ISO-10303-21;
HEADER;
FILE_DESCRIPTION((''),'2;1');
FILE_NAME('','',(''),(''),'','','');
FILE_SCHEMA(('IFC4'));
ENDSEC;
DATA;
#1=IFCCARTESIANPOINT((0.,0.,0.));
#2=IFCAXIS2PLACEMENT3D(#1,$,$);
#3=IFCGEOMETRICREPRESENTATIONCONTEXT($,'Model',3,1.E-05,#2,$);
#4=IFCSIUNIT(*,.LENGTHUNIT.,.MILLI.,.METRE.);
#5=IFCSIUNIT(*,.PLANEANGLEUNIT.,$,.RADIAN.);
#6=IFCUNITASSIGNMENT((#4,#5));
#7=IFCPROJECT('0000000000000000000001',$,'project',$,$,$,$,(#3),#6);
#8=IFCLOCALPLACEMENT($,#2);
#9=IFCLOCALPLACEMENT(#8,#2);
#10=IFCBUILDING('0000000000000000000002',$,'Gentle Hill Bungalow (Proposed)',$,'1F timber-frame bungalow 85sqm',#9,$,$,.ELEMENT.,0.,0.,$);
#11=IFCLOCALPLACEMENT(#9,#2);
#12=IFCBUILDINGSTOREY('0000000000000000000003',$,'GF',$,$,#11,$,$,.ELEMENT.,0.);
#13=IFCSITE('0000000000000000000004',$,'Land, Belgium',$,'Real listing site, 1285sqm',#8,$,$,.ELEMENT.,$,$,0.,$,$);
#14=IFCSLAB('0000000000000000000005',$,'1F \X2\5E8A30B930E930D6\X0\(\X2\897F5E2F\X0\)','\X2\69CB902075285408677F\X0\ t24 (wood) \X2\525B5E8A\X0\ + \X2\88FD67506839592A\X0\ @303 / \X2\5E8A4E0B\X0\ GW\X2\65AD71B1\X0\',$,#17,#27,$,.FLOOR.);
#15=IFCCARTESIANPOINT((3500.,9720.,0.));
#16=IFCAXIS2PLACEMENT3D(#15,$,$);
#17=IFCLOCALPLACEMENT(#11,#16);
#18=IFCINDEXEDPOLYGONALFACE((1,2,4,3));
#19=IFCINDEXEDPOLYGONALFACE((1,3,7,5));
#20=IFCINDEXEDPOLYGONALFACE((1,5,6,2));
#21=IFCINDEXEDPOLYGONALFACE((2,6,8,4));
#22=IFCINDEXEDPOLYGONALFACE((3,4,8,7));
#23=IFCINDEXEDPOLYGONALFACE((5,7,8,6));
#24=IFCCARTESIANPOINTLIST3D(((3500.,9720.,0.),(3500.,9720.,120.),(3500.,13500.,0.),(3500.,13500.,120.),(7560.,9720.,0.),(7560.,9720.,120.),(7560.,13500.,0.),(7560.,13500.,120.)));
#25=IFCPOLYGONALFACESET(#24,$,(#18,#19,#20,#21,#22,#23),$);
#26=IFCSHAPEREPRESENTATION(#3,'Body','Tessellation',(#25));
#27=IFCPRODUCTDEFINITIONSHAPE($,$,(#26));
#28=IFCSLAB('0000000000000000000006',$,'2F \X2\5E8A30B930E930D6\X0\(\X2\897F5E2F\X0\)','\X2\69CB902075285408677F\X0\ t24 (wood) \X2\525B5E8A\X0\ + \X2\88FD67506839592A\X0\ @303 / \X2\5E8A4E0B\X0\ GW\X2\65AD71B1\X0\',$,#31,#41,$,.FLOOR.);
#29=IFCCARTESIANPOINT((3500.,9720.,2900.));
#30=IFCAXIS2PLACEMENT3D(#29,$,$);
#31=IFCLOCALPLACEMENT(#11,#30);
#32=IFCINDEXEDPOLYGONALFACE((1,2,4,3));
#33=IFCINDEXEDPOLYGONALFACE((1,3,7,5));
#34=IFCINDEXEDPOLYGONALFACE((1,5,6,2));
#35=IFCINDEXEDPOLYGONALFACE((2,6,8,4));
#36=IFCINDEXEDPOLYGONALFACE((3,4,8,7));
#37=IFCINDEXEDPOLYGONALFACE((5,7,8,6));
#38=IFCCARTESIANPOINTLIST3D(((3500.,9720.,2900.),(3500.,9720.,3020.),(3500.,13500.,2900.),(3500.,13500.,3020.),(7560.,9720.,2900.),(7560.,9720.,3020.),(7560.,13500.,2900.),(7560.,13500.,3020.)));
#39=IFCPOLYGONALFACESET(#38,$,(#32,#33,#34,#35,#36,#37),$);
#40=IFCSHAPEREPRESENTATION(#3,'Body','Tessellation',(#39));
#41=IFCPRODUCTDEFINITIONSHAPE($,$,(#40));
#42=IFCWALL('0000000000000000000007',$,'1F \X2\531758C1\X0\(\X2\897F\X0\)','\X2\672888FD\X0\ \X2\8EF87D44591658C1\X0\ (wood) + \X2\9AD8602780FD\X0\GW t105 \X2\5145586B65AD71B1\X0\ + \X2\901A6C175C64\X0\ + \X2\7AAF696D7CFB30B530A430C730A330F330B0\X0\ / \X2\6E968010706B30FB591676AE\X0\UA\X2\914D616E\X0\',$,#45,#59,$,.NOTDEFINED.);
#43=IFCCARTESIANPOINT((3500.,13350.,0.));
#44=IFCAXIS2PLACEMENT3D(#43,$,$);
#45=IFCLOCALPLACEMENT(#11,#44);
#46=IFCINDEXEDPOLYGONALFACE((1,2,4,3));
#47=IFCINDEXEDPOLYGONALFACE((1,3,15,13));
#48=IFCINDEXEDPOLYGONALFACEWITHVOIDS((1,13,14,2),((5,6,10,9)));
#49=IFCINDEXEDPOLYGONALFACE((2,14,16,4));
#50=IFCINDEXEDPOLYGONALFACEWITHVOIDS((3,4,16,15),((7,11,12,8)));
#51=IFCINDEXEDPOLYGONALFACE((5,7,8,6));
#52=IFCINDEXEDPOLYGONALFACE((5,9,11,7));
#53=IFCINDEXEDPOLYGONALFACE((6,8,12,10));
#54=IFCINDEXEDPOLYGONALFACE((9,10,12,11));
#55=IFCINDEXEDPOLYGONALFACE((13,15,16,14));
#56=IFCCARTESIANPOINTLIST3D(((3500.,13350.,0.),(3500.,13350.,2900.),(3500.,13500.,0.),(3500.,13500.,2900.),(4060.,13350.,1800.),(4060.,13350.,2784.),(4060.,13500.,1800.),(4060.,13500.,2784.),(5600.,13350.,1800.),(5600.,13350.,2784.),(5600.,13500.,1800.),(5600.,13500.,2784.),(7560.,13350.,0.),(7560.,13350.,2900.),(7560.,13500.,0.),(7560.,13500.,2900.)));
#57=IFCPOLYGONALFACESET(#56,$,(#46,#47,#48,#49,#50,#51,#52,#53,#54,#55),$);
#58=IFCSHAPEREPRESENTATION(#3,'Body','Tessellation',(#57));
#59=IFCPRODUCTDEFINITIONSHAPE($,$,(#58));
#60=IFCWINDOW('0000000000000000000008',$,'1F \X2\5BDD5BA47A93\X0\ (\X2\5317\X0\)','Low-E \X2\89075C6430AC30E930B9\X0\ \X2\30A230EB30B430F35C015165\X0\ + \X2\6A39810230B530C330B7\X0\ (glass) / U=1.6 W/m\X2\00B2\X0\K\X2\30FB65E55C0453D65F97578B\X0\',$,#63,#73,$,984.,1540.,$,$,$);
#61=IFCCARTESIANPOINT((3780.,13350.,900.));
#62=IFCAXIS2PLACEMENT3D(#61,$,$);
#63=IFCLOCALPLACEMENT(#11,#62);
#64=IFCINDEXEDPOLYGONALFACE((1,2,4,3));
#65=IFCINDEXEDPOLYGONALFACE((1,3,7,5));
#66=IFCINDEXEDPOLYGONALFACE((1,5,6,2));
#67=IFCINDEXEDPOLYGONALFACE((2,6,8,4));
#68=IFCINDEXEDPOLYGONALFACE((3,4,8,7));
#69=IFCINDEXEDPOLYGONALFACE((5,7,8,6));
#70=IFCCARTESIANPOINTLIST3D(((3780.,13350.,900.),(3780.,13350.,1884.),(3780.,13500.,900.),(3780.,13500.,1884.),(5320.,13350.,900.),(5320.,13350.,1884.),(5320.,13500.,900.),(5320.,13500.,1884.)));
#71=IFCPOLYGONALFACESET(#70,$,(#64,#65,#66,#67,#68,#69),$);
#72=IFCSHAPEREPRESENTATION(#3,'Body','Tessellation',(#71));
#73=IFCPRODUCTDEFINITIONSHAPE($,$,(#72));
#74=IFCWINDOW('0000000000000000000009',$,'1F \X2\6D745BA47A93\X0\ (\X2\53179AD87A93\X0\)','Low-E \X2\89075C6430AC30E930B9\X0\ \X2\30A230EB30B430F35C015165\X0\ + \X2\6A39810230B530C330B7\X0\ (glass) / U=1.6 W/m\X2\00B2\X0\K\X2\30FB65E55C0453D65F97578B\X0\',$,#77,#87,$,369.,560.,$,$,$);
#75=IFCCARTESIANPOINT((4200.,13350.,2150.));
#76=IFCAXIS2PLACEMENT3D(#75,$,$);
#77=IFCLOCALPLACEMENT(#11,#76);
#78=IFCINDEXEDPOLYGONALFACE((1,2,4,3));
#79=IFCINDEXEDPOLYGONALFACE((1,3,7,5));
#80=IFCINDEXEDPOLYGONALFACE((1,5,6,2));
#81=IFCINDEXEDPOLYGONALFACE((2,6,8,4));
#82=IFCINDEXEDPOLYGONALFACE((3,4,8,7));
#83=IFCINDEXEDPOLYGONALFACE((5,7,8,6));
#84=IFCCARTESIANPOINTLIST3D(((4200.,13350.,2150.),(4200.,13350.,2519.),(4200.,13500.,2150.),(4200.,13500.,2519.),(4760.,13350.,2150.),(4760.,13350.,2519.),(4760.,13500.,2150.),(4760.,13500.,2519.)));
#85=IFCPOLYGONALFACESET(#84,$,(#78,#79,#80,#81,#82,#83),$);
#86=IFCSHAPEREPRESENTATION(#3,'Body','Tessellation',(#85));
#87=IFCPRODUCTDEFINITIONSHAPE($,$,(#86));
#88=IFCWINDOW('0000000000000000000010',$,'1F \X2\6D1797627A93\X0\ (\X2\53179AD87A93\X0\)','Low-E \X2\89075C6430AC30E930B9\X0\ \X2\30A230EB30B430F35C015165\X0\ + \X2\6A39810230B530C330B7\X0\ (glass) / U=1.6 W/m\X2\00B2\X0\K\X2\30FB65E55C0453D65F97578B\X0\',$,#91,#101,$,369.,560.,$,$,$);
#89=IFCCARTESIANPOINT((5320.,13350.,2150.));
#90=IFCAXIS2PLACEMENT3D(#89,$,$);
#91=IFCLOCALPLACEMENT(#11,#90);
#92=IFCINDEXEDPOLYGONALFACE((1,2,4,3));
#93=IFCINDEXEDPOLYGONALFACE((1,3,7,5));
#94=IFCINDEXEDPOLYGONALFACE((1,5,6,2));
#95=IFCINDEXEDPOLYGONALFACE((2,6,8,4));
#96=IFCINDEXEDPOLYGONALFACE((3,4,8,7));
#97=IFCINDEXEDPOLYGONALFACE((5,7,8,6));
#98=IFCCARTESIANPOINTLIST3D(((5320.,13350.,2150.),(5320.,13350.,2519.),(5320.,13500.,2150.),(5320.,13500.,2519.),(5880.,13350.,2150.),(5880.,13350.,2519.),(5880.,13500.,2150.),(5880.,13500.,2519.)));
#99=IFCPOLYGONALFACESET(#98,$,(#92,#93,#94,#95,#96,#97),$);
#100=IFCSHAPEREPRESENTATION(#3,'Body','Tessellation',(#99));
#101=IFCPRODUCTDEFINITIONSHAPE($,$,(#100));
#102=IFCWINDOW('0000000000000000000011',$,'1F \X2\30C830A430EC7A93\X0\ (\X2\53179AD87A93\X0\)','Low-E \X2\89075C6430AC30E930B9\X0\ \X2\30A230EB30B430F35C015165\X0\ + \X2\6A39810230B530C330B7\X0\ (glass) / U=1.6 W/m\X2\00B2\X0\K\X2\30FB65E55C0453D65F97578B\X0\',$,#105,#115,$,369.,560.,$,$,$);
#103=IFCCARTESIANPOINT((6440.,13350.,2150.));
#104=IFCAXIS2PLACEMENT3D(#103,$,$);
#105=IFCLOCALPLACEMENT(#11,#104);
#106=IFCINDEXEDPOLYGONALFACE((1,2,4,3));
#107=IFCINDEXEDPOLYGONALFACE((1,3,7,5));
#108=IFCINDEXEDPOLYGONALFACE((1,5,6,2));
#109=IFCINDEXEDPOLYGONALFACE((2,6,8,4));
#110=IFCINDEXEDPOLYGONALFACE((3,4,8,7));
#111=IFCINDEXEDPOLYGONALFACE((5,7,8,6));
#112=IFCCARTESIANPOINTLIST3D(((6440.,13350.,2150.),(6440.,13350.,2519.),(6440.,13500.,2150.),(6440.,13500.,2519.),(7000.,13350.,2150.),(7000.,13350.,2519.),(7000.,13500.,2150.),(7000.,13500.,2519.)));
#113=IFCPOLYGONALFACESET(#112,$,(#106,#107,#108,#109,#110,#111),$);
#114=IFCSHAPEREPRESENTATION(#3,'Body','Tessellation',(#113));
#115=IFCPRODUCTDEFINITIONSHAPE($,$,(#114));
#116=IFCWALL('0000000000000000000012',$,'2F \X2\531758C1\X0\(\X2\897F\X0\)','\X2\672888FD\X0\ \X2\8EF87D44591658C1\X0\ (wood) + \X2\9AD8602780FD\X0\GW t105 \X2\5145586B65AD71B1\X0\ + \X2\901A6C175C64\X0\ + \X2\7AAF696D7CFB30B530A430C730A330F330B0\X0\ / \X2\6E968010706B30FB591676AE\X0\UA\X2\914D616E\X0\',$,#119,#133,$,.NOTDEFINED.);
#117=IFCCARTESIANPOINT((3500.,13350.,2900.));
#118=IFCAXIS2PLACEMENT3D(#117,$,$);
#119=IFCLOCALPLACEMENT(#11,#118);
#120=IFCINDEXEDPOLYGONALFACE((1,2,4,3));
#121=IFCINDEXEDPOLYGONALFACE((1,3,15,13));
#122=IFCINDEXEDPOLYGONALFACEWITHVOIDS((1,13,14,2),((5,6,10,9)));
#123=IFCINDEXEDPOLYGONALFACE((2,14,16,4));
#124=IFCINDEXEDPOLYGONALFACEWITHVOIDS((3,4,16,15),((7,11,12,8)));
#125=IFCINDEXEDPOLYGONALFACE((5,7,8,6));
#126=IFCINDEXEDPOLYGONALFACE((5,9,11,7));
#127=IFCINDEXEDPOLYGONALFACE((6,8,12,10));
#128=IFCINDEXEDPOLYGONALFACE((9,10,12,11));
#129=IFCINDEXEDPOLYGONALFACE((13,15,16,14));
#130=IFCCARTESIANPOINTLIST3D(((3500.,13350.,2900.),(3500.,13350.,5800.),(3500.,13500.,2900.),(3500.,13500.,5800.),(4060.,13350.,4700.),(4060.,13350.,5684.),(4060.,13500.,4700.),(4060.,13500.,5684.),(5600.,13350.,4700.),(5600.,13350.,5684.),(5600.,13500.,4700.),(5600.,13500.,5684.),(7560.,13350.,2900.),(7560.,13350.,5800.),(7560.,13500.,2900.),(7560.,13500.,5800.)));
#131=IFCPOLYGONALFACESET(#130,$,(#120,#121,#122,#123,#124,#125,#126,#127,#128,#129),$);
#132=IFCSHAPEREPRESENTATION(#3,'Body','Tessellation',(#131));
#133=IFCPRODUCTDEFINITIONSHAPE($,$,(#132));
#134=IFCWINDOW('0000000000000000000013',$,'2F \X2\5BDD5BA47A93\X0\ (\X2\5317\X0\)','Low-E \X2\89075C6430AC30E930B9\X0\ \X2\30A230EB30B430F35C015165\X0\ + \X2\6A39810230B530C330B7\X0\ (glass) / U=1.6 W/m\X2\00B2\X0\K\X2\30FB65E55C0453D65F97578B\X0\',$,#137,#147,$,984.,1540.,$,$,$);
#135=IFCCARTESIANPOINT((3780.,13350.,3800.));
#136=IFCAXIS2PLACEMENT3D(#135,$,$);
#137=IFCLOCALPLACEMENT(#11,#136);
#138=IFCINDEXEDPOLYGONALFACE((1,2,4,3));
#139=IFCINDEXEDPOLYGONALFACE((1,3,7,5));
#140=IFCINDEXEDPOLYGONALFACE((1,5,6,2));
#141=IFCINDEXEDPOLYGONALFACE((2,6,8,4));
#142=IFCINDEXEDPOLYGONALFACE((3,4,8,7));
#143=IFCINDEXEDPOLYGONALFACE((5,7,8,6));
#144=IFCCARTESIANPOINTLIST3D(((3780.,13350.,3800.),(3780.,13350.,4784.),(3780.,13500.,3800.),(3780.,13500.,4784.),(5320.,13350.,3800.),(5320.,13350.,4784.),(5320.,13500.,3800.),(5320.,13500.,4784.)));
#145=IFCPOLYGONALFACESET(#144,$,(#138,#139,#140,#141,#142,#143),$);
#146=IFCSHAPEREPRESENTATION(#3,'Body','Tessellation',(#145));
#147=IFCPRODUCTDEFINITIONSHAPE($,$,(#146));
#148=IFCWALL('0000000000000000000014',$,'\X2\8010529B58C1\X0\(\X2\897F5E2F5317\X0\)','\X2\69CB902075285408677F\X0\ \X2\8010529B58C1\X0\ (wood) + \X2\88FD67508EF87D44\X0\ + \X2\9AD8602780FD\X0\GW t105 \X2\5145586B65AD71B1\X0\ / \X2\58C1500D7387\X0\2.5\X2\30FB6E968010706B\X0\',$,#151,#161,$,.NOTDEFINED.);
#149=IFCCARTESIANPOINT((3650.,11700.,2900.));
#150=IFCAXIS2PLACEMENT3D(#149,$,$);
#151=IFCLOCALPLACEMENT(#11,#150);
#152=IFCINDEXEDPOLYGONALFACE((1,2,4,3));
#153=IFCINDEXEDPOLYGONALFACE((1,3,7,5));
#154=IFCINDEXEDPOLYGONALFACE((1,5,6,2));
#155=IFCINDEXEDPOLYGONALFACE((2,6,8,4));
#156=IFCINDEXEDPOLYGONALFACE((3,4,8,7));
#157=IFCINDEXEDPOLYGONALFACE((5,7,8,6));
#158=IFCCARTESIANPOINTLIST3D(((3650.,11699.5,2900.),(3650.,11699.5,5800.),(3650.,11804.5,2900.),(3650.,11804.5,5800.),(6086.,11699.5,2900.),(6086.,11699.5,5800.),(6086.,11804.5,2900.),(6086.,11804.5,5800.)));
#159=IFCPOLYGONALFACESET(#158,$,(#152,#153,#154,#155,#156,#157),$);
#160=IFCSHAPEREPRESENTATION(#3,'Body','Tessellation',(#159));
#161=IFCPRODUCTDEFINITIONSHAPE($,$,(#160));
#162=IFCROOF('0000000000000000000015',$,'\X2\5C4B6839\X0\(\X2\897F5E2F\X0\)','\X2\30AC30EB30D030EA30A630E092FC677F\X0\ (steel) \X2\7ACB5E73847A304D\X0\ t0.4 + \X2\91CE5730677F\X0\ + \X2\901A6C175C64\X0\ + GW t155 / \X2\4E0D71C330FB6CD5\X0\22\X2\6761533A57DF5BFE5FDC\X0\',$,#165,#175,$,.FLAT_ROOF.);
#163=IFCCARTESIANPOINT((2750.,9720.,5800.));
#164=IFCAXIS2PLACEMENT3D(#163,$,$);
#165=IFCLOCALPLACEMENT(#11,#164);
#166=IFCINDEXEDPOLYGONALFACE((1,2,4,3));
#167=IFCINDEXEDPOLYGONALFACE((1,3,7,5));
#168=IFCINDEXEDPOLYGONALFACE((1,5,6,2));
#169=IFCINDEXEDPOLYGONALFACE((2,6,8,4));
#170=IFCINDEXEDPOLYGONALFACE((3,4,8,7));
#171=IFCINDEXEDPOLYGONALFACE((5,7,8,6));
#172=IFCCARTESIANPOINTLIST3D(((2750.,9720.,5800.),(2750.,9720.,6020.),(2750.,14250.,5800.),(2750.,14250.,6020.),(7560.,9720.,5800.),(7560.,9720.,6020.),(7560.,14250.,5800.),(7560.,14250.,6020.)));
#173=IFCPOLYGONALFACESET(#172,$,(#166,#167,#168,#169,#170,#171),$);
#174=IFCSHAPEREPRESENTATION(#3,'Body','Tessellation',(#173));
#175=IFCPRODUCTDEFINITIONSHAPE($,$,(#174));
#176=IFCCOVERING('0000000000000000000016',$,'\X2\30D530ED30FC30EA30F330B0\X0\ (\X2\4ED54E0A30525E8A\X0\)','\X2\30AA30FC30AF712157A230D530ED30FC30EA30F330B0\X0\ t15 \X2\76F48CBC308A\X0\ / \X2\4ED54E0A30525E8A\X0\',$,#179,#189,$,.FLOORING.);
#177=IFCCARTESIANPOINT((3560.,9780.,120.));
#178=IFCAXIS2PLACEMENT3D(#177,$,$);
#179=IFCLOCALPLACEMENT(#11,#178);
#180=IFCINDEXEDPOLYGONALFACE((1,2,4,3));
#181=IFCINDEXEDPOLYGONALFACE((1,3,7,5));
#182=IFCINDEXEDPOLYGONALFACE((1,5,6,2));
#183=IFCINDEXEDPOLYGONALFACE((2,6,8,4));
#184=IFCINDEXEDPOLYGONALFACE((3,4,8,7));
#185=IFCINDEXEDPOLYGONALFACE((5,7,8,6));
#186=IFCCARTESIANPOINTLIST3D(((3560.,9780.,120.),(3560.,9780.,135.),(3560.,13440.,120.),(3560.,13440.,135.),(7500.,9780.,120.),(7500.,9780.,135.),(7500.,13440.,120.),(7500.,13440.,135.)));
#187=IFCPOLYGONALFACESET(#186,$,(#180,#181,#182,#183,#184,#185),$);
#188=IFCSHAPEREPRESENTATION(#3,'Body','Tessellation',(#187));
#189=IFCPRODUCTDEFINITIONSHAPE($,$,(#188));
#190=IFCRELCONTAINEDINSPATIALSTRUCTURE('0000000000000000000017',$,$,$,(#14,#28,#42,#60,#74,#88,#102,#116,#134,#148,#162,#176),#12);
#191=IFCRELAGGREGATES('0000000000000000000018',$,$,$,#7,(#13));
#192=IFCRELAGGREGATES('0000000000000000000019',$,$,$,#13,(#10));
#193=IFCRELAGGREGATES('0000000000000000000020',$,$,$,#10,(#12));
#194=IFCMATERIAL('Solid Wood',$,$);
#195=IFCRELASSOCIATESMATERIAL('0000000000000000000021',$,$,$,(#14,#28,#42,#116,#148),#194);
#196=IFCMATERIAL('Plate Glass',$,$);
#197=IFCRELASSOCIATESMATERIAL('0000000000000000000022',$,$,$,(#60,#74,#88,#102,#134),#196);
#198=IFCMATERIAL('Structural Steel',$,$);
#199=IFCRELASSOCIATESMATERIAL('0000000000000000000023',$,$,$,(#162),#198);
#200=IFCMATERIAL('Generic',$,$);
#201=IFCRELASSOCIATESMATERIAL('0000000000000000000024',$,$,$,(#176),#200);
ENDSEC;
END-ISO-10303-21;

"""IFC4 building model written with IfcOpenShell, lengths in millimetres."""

from ifc_helpers import new_model, si_unit, frame, frame_2d, origin, place, context, project, spatial, rectangle, extrude, material, element, fill, save


model = new_model("IFC4")

# Units and contexts
model_context = context("Model", 3, precision=1e-05, world=origin())
ifc_project = project(units=[si_unit("LENGTHUNIT", "METRE", prefix="MILLI"), si_unit("PLANEANGLEUNIT", "RADIAN")], contexts=[model_context])

# Site, building, storey
site_placement = place(None, origin())
site = spatial("IfcSite", under=ifc_project, at=site_placement, Name="Land, Belgium", ObjectType="Real listing site, 1285sqm", CompositionType="ELEMENT", RefElevation=0.0)
building_placement = place(site_placement, origin())
building = spatial("IfcBuilding", under=site, at=building_placement, Name="Gentle Hill Bungalow (Proposed)", ObjectType="1F timber-frame bungalow 85sqm", CompositionType="ELEMENT", ElevationOfRefHeight=0.0, ElevationOfTerrain=0.0)
storey_placement = place(building_placement, origin())
storey = spatial("IfcBuildingStorey", under=building, at=storey_placement, Name="GF", CompositionType="ELEMENT", Elevation=0.0)

# Slabs
ifc_material_1 = material(Name="Solid Wood")
slab_1_placement = place(storey_placement, frame((3500.0, 9720.0, 0.0)))
element("IfcSlab", 1, at=slab_1_placement, inside=storey, material=ifc_material_1, Name="1F 床スラブ(西帯)", Description="構造用合板 t24 (wood) 剛床 + 製材根太 @303 / 床下 GW断熱", PredefinedType="FLOOR", context=model_context, shape_type="SweptSolid", body=[
    extrude(rectangle(XDim=4060.0, YDim=3780.0, at=frame_2d((2030.0, 1890.0))), frame((3500.0, 9720.0, 0.0)), (0.0, 0.0, 1.0), 120.0),
])
slab_2_placement = place(storey_placement, frame((3500.0, 9720.0, 2900.0)))
element("IfcSlab", 2, at=slab_2_placement, inside=storey, material=ifc_material_1, Name="2F 床スラブ(西帯)", Description="構造用合板 t24 (wood) 剛床 + 製材根太 @303 / 床下 GW断熱", PredefinedType="FLOOR", context=model_context, shape_type="SweptSolid", body=[
    extrude(rectangle(XDim=4060.0, YDim=3780.0, at=frame_2d((2030.0, 1890.0))), frame((3500.0, 9720.0, 2900.0)), (0.0, 0.0, 1.0), 120.0),
])

# Wall, openings, windows
wall_1_placement = place(storey_placement, frame((3500.0, 13350.0, 0.0)))
wall_1 = element("IfcWall", 3, at=wall_1_placement, inside=storey, material=ifc_material_1, Name="1F 北壁(西)", Description="木製 軸組外壁 (wood) + 高性能GW t105 充填断熱 + 通気層 + 窯業系サイディング / 準耐火・外皮UA配慮", PredefinedType="NOTDEFINED", context=model_context, shape_type="SweptSolid", body=[
    extrude(rectangle(XDim=4060.0, YDim=150.0, at=frame_2d((2030.0, 75.0))), frame((3500.0, 13350.0, 0.0)), (0.0, 0.0, 1.0), 2900.0),
])
opening_1_placement = place(storey_placement, frame((3780.0, 13350.0, 900.0)))
opening_1 = element("IfcOpeningElement", 4, at=opening_1_placement, cuts=wall_1, PredefinedType="NOTDEFINED", context=model_context, shape_type="SweptSolid", body=[
    extrude(rectangle(XDim=1540.0, YDim=150.0, at=frame_2d((770.0, 75.0))), frame((3780.0, 13350.0, 900.0)), (0.0, 0.0, 1.0), 984.0),
])
opening_2_placement = place(storey_placement, frame((4200.0, 13350.0, 2150.0)))
opening_2 = element("IfcOpeningElement", 5, at=opening_2_placement, cuts=wall_1, PredefinedType="NOTDEFINED", context=model_context, shape_type="SweptSolid", body=[
    extrude(rectangle(XDim=560.0, YDim=150.0, at=frame_2d((280.0, 75.0))), frame((4200.0, 13350.0, 2150.0)), (0.0, 0.0, 1.0), 369.0),
])
opening_3_placement = place(storey_placement, frame((5320.0, 13350.0, 2150.0)))
opening_3 = element("IfcOpeningElement", 6, at=opening_3_placement, cuts=wall_1, PredefinedType="NOTDEFINED", context=model_context, shape_type="SweptSolid", body=[
    extrude(rectangle(XDim=560.0, YDim=150.0, at=frame_2d((280.0, 75.0))), frame((5320.0, 13350.0, 2150.0)), (0.0, 0.0, 1.0), 369.0),
])
opening_4_placement = place(storey_placement, frame((6440.0, 13350.0, 2150.0)))
opening_4 = element("IfcOpeningElement", 7, at=opening_4_placement, cuts=wall_1, PredefinedType="NOTDEFINED", context=model_context, shape_type="SweptSolid", body=[
    extrude(rectangle(XDim=560.0, YDim=150.0, at=frame_2d((280.0, 75.0))), frame((6440.0, 13350.0, 2150.0)), (0.0, 0.0, 1.0), 369.0),
])
ifc_material_2 = material(Name="Plate Glass")
window_1_placement = place(storey_placement, frame((3780.0, 13350.0, 900.0)))
window_1 = element("IfcWindow", 8, at=window_1_placement, inside=storey, material=ifc_material_2, Name="1F 寝室窓 (北)", Description="Low-E 複層ガラス アルゴン封入 + 樹脂サッシ (glass) / U=1.6 W/m²K・日射取得型", OverallHeight=984.0, OverallWidth=1540.0, context=model_context, shape_type="SweptSolid", body=[
    extrude(rectangle(XDim=1540.0, YDim=150.0, at=frame_2d((770.0, 75.0))), frame((3780.0, 13350.0, 900.0)), (0.0, 0.0, 1.0), 984.0),
])
fill(opening_1, window_1)
window_2_placement = place(storey_placement, frame((4200.0, 13350.0, 2150.0)))
window_2 = element("IfcWindow", 9, at=window_2_placement, inside=storey, material=ifc_material_2, Name="1F 浴室窓 (北高窓)", Description="Low-E 複層ガラス アルゴン封入 + 樹脂サッシ (glass) / U=1.6 W/m²K・日射取得型", OverallHeight=369.0, OverallWidth=560.0, context=model_context, shape_type="SweptSolid", body=[
    extrude(rectangle(XDim=560.0, YDim=150.0, at=frame_2d((280.0, 75.0))), frame((4200.0, 13350.0, 2150.0)), (0.0, 0.0, 1.0), 369.0),
])
fill(opening_2, window_2)
window_3_placement = place(storey_placement, frame((5320.0, 13350.0, 2150.0)))
window_3 = element("IfcWindow", 10, at=window_3_placement, inside=storey, material=ifc_material_2, Name="1F 洗面窓 (北高窓)", Description="Low-E 複層ガラス アルゴン封入 + 樹脂サッシ (glass) / U=1.6 W/m²K・日射取得型", OverallHeight=369.0, OverallWidth=560.0, context=model_context, shape_type="SweptSolid", body=[
    extrude(rectangle(XDim=560.0, YDim=150.0, at=frame_2d((280.0, 75.0))), frame((5320.0, 13350.0, 2150.0)), (0.0, 0.0, 1.0), 369.0),
])
fill(opening_3, window_3)
window_4_placement = place(storey_placement, frame((6440.0, 13350.0, 2150.0)))
window_4 = element("IfcWindow", 11, at=window_4_placement, inside=storey, material=ifc_material_2, Name="1F トイレ窓 (北高窓)", Description="Low-E 複層ガラス アルゴン封入 + 樹脂サッシ (glass) / U=1.6 W/m²K・日射取得型", OverallHeight=369.0, OverallWidth=560.0, context=model_context, shape_type="SweptSolid", body=[
    extrude(rectangle(XDim=560.0, YDim=150.0, at=frame_2d((280.0, 75.0))), frame((6440.0, 13350.0, 2150.0)), (0.0, 0.0, 1.0), 369.0),
])
fill(opening_4, window_4)

# Wall, opening, window
wall_2_placement = place(storey_placement, frame((3500.0, 13350.0, 2900.0)))
wall_2 = element("IfcWall", 12, at=wall_2_placement, inside=storey, material=ifc_material_1, Name="2F 北壁(西)", Description="木製 軸組外壁 (wood) + 高性能GW t105 充填断熱 + 通気層 + 窯業系サイディング / 準耐火・外皮UA配慮", PredefinedType="NOTDEFINED", context=model_context, shape_type="SweptSolid", body=[
    extrude(rectangle(XDim=4060.0, YDim=150.0, at=frame_2d((2030.0, 75.0))), frame((3500.0, 13350.0, 2900.0)), (0.0, 0.0, 1.0), 2900.0),
])
opening_5_placement = place(storey_placement, frame((3780.0, 13350.0, 3800.0)))
opening_5 = element("IfcOpeningElement", 13, at=opening_5_placement, cuts=wall_2, PredefinedType="NOTDEFINED", context=model_context, shape_type="SweptSolid", body=[
    extrude(rectangle(XDim=1540.0, YDim=150.0, at=frame_2d((770.0, 75.0))), frame((3780.0, 13350.0, 3800.0)), (0.0, 0.0, 1.0), 984.0),
])
window_5_placement = place(storey_placement, frame((3780.0, 13350.0, 3800.0)))
window_5 = element("IfcWindow", 14, at=window_5_placement, inside=storey, material=ifc_material_2, Name="2F 寝室窓 (北)", Description="Low-E 複層ガラス アルゴン封入 + 樹脂サッシ (glass) / U=1.6 W/m²K・日射取得型", OverallHeight=984.0, OverallWidth=1540.0, context=model_context, shape_type="SweptSolid", body=[
    extrude(rectangle(XDim=1540.0, YDim=150.0, at=frame_2d((770.0, 75.0))), frame((3780.0, 13350.0, 3800.0)), (0.0, 0.0, 1.0), 984.0),
])
fill(opening_5, window_5)

# Wall
wall_3_placement = place(storey_placement, frame((3650.0, 11700.0, 2900.0)))
element("IfcWall", 15, at=wall_3_placement, inside=storey, material=ifc_material_1, Name="耐力壁(西帯北)", Description="構造用合板 耐力壁 (wood) + 製材軸組 + 高性能GW t105 充填断熱 / 壁倍率2.5・準耐火", PredefinedType="NOTDEFINED", context=model_context, shape_type="SweptSolid", body=[
    extrude(rectangle(XDim=2436.0, YDim=105.0, at=frame_2d((1218.0, 52.0))), frame((3650.0, 11700.0, 2900.0)), (0.0, 0.0, 1.0), 2900.0),
])

# Roof
ifc_material_3 = material(Name="Structural Steel")
for number, where, name in (
    (16, (2750.0, 9720.0, 5800.0), "屋根(西帯)"),
):
    element("IfcRoof", number, at=place(storey_placement, frame(where)), inside=storey, material=ifc_material_3, Name=name, Description="ガルバリウム鋼板 (steel) 立平葺き t0.4 + 野地板 + 通気層 + GW t155 / 不燃・法22条区域対応", PredefinedType="FLAT_ROOF", context=model_context, shape_type="SweptSolid", body=[
        extrude(rectangle(XDim=4810.0, YDim=4530.0, at=frame_2d((2405.0, 2265.0))), frame((2750.0, 9720.0, 5800.0)), (0.0, 0.0, 1.0), 220.0),
    ])

# Covering
ifc_material_4 = material(Name="Generic")
covering_1_placement = place(storey_placement, frame((3560.0, 9780.0, 120.0)))
element("IfcCovering", 17, at=covering_1_placement, inside=storey, material=ifc_material_4, Name="フローリング (仕上げ床)", Description="オーク無垢フローリング t15 直貼り / 仕上げ床", PredefinedType="FLOORING", context=model_context, shape_type="SweptSolid", body=[
    extrude(rectangle(XDim=3940.0, YDim=3660.0, at=frame_2d((1970.0, 1830.0))), frame((3560.0, 9780.0, 120.0)), (0.0, 0.0, 1.0), 15.0),
])

save(model, "model.ifc")
